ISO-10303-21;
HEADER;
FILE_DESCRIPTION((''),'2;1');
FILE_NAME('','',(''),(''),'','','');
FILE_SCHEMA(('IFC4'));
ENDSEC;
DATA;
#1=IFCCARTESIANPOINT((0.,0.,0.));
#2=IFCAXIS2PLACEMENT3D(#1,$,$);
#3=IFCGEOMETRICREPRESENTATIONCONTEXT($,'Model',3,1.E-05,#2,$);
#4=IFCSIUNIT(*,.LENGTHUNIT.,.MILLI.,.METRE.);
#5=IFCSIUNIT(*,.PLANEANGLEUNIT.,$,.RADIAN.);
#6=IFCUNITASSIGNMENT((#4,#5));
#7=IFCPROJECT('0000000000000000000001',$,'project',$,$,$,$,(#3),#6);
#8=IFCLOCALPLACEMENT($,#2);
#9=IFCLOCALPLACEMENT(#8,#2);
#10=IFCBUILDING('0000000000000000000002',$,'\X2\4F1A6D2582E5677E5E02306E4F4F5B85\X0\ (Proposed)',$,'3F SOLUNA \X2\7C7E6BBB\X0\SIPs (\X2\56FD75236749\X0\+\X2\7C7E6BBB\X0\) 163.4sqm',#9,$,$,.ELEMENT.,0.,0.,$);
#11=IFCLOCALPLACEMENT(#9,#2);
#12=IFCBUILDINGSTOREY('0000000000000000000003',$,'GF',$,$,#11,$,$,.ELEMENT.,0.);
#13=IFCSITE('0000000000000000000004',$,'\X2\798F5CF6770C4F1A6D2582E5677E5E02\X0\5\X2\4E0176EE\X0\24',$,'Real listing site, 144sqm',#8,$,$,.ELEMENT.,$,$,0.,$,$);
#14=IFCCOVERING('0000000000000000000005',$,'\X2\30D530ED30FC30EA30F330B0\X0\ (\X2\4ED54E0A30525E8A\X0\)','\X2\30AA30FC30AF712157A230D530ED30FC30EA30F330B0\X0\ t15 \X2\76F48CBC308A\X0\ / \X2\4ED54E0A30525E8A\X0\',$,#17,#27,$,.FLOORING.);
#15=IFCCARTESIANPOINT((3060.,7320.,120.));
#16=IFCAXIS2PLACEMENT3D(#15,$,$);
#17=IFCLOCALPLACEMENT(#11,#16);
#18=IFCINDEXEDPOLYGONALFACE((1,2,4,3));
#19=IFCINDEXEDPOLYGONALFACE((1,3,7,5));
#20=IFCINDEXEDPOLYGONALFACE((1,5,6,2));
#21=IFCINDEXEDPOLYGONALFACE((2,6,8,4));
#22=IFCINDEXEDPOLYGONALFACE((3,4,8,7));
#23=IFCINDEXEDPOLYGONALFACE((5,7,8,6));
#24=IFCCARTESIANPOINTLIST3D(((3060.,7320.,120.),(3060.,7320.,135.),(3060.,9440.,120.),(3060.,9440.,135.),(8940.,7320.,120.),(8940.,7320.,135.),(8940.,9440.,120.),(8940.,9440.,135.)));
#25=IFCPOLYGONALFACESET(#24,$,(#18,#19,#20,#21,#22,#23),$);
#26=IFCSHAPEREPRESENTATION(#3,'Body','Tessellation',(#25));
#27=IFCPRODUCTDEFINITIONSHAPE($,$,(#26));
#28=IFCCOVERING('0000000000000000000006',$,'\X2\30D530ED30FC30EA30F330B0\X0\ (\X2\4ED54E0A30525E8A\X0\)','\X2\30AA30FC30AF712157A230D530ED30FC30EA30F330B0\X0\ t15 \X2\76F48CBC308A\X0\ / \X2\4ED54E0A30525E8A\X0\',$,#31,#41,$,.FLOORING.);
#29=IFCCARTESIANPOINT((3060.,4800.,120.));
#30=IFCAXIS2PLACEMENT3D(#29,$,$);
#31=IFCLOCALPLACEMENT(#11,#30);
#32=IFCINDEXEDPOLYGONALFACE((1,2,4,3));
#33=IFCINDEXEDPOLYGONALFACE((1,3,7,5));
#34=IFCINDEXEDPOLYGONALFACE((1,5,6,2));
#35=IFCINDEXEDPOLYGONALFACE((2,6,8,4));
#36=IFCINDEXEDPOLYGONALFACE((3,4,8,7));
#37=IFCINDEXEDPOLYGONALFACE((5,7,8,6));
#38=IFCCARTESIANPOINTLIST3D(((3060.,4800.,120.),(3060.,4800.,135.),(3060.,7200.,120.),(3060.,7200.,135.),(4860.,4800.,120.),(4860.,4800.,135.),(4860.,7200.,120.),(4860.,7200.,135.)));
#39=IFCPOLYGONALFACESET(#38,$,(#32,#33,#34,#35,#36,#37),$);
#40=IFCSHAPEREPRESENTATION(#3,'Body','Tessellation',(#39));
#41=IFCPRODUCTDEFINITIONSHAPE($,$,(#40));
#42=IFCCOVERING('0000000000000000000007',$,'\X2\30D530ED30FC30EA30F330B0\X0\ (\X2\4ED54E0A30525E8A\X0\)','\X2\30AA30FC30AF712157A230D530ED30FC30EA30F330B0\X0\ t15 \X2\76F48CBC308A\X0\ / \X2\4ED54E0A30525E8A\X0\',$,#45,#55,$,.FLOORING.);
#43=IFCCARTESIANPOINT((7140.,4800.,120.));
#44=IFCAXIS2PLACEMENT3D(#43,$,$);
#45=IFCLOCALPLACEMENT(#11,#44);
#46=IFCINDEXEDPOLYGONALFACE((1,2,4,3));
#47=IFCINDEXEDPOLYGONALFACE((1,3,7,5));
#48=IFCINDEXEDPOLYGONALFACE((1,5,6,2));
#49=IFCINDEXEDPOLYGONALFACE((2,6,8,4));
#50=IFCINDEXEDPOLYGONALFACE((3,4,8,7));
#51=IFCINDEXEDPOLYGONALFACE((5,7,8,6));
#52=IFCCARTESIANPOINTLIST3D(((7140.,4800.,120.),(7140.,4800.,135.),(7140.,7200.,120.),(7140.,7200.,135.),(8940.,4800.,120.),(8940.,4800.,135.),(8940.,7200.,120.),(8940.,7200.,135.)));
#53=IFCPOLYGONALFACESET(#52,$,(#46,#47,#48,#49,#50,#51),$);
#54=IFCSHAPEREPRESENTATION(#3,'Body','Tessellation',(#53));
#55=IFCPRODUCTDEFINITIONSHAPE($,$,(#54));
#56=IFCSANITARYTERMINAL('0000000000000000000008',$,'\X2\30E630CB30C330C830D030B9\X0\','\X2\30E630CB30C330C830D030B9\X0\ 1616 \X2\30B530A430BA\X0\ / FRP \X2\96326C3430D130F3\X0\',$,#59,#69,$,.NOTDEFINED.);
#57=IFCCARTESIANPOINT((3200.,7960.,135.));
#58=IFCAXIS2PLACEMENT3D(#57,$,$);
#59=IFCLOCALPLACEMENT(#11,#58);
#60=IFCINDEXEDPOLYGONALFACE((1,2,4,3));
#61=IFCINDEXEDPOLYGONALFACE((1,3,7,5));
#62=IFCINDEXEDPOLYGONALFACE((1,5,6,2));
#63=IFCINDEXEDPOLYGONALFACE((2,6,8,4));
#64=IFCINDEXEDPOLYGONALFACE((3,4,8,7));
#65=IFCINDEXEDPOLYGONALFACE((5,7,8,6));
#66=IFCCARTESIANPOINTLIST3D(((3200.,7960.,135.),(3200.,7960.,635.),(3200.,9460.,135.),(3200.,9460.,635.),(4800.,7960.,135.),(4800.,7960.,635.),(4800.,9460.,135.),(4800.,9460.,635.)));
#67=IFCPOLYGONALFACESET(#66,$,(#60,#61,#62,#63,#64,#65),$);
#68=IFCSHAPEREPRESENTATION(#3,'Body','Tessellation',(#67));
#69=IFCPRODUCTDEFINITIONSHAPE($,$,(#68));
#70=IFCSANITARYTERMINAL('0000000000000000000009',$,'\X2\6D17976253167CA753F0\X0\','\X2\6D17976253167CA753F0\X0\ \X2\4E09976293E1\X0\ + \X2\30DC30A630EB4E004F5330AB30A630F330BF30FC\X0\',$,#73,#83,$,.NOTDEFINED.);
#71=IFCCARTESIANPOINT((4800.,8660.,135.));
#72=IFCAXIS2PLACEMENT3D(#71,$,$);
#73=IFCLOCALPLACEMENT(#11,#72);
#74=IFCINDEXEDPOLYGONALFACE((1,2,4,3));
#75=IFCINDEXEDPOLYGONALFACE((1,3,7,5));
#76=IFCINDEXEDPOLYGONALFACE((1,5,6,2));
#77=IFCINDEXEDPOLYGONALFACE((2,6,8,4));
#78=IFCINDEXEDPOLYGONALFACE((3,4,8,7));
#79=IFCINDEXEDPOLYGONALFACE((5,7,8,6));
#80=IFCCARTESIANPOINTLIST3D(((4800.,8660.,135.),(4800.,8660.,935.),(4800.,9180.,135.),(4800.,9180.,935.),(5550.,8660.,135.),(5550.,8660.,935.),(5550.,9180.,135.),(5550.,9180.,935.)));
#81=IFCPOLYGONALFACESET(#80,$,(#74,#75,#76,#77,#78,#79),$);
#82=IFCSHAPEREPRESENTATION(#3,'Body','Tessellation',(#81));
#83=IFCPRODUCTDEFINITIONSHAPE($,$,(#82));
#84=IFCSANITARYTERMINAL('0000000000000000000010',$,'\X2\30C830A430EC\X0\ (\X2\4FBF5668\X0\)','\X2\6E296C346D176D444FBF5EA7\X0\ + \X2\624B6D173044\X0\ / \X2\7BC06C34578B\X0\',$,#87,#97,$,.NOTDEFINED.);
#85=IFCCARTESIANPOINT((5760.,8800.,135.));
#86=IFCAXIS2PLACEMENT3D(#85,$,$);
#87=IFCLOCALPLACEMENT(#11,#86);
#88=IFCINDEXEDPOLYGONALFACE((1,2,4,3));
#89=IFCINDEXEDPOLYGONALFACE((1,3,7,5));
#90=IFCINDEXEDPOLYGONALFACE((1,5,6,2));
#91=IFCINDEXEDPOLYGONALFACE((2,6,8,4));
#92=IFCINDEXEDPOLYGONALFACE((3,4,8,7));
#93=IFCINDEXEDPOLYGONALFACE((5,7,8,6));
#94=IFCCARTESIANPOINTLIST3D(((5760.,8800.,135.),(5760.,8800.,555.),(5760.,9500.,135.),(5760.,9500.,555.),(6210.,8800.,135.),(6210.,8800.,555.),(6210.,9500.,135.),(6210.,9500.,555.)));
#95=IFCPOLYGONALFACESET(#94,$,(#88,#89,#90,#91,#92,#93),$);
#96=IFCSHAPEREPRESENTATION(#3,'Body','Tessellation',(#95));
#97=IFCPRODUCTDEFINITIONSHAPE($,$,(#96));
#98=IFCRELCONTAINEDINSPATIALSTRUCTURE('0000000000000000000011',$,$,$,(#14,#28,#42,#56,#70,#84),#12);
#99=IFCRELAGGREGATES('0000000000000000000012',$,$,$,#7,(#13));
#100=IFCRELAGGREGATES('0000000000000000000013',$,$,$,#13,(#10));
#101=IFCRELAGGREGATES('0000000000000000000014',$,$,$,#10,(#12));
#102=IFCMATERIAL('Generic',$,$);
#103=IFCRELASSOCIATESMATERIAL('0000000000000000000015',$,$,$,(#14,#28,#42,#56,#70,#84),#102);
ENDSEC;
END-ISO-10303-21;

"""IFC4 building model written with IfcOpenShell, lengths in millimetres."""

from ifc_helpers import new_model, si_unit, frame, frame_2d, origin, place, context, project, spatial, rectangle, extrude, material, element, save


model = new_model("IFC4")

# Units and contexts
model_context = context("Model", 3, precision=1e-05, world=origin())
ifc_project = project(units=[si_unit("LENGTHUNIT", "METRE", prefix="MILLI"), si_unit("PLANEANGLEUNIT", "RADIAN")], contexts=[model_context])

# Site, building, storey
site_placement = place(None, origin())
site = spatial("IfcSite", under=ifc_project, at=site_placement, Name="福島県会津若松市5丁目24", ObjectType="Real listing site, 144sqm", CompositionType="ELEMENT", RefElevation=0.0)
building_placement = place(site_placement, origin())
building = spatial("IfcBuilding", under=site, at=building_placement, Name="会津若松市の住宅 (Proposed)", ObjectType="3F SOLUNA 籾殻SIPs (国産杉+籾殻) 163.4sqm", CompositionType="ELEMENT", ElevationOfRefHeight=0.0, ElevationOfTerrain=0.0)
storey_placement = place(building_placement, origin())
storey = spatial("IfcBuildingStorey", under=building, at=storey_placement, Name="GF", CompositionType="ELEMENT", Elevation=0.0)

# Coverings
ifc_material_1 = material(Name="Generic")
covering_1_placement = place(storey_placement, frame((3060.0, 7320.0, 120.0)))
element("IfcCovering", 1, at=covering_1_placement, inside=storey, material=ifc_material_1, Name="フローリング (仕上げ床)", Description="オーク無垢フローリング t15 直貼り / 仕上げ床", PredefinedType="FLOORING", context=model_context, shape_type="SweptSolid", body=[
    extrude(rectangle(XDim=5880.0, YDim=2120.0, at=frame_2d((2940.0, 1060.0))), frame((3060.0, 7320.0, 120.0)), (0.0, 0.0, 1.0), 15.0),
])
covering_2_placement = place(storey_placement, frame((3060.0, 4800.0, 120.0)))
element("IfcCovering", 2, at=covering_2_placement, inside=storey, material=ifc_material_1, Name="フローリング (仕上げ床)", Description="オーク無垢フローリング t15 直貼り / 仕上げ床", PredefinedType="FLOORING", context=model_context, shape_type="SweptSolid", body=[
    extrude(rectangle(XDim=1800.0, YDim=2400.0, at=frame_2d((900.0, 1200.0))), frame((3060.0, 4800.0, 120.0)), (0.0, 0.0, 1.0), 15.0),
])
covering_3_placement = place(storey_placement, frame((7140.0, 4800.0, 120.0)))
element("IfcCovering", 3, at=covering_3_placement, inside=storey, material=ifc_material_1, Name="フローリング (仕上げ床)", Description="オーク無垢フローリング t15 直貼り / 仕上げ床", PredefinedType="FLOORING", context=model_context, shape_type="SweptSolid", body=[
    extrude(rectangle(XDim=1800.0, YDim=2400.0, at=frame_2d((900.0, 1200.0))), frame((7140.0, 4800.0, 120.0)), (0.0, 0.0, 1.0), 15.0),
])

# Sanitary terminals
sanitary_terminal_1_placement = place(storey_placement, frame((3200.0, 7960.0, 135.0)))
element("IfcSanitaryTerminal", 4, at=sanitary_terminal_1_placement, inside=storey, material=ifc_material_1, Name="ユニットバス", Description="ユニットバス 1616 サイズ / FRP 防水パン", PredefinedType="NOTDEFINED", context=model_context, shape_type="SweptSolid", body=[
    extrude(rectangle(XDim=1600.0, YDim=1500.0, at=frame_2d((800.0, 750.0))), frame((3200.0, 7960.0, 135.0)), (0.0, 0.0, 1.0), 500.0),
])
sanitary_terminal_2_placement = place(storey_placement, frame((4800.0, 8660.0, 135.0)))
element("IfcSanitaryTerminal", 5, at=sanitary_terminal_2_placement, inside=storey, material=ifc_material_1, Name="洗面化粧台", Description="洗面化粧台 三面鏡 + ボウル一体カウンター", PredefinedType="NOTDEFINED", context=model_context, shape_type="SweptSolid", body=[
    extrude(rectangle(XDim=750.0, YDim=520.0, at=frame_2d((375.0, 260.0))), frame((4800.0, 8660.0, 135.0)), (0.0, 0.0, 1.0), 800.0),
])
sanitary_terminal_3_placement = place(storey_placement, frame((5760.0, 8800.0, 135.0)))
element("IfcSanitaryTerminal", 6, at=sanitary_terminal_3_placement, inside=storey, material=ifc_material_1, Name="トイレ (便器)", Description="温水洗浄便座 + 手洗い / 節水型", PredefinedType="NOTDEFINED", context=model_context, shape_type="SweptSolid", body=[
    extrude(rectangle(XDim=450.0, YDim=700.0, at=frame_2d((225.0, 350.0))), frame((5760.0, 8800.0, 135.0)), (0.0, 0.0, 1.0), 420.0),
])

save(model, "model.ifc")
